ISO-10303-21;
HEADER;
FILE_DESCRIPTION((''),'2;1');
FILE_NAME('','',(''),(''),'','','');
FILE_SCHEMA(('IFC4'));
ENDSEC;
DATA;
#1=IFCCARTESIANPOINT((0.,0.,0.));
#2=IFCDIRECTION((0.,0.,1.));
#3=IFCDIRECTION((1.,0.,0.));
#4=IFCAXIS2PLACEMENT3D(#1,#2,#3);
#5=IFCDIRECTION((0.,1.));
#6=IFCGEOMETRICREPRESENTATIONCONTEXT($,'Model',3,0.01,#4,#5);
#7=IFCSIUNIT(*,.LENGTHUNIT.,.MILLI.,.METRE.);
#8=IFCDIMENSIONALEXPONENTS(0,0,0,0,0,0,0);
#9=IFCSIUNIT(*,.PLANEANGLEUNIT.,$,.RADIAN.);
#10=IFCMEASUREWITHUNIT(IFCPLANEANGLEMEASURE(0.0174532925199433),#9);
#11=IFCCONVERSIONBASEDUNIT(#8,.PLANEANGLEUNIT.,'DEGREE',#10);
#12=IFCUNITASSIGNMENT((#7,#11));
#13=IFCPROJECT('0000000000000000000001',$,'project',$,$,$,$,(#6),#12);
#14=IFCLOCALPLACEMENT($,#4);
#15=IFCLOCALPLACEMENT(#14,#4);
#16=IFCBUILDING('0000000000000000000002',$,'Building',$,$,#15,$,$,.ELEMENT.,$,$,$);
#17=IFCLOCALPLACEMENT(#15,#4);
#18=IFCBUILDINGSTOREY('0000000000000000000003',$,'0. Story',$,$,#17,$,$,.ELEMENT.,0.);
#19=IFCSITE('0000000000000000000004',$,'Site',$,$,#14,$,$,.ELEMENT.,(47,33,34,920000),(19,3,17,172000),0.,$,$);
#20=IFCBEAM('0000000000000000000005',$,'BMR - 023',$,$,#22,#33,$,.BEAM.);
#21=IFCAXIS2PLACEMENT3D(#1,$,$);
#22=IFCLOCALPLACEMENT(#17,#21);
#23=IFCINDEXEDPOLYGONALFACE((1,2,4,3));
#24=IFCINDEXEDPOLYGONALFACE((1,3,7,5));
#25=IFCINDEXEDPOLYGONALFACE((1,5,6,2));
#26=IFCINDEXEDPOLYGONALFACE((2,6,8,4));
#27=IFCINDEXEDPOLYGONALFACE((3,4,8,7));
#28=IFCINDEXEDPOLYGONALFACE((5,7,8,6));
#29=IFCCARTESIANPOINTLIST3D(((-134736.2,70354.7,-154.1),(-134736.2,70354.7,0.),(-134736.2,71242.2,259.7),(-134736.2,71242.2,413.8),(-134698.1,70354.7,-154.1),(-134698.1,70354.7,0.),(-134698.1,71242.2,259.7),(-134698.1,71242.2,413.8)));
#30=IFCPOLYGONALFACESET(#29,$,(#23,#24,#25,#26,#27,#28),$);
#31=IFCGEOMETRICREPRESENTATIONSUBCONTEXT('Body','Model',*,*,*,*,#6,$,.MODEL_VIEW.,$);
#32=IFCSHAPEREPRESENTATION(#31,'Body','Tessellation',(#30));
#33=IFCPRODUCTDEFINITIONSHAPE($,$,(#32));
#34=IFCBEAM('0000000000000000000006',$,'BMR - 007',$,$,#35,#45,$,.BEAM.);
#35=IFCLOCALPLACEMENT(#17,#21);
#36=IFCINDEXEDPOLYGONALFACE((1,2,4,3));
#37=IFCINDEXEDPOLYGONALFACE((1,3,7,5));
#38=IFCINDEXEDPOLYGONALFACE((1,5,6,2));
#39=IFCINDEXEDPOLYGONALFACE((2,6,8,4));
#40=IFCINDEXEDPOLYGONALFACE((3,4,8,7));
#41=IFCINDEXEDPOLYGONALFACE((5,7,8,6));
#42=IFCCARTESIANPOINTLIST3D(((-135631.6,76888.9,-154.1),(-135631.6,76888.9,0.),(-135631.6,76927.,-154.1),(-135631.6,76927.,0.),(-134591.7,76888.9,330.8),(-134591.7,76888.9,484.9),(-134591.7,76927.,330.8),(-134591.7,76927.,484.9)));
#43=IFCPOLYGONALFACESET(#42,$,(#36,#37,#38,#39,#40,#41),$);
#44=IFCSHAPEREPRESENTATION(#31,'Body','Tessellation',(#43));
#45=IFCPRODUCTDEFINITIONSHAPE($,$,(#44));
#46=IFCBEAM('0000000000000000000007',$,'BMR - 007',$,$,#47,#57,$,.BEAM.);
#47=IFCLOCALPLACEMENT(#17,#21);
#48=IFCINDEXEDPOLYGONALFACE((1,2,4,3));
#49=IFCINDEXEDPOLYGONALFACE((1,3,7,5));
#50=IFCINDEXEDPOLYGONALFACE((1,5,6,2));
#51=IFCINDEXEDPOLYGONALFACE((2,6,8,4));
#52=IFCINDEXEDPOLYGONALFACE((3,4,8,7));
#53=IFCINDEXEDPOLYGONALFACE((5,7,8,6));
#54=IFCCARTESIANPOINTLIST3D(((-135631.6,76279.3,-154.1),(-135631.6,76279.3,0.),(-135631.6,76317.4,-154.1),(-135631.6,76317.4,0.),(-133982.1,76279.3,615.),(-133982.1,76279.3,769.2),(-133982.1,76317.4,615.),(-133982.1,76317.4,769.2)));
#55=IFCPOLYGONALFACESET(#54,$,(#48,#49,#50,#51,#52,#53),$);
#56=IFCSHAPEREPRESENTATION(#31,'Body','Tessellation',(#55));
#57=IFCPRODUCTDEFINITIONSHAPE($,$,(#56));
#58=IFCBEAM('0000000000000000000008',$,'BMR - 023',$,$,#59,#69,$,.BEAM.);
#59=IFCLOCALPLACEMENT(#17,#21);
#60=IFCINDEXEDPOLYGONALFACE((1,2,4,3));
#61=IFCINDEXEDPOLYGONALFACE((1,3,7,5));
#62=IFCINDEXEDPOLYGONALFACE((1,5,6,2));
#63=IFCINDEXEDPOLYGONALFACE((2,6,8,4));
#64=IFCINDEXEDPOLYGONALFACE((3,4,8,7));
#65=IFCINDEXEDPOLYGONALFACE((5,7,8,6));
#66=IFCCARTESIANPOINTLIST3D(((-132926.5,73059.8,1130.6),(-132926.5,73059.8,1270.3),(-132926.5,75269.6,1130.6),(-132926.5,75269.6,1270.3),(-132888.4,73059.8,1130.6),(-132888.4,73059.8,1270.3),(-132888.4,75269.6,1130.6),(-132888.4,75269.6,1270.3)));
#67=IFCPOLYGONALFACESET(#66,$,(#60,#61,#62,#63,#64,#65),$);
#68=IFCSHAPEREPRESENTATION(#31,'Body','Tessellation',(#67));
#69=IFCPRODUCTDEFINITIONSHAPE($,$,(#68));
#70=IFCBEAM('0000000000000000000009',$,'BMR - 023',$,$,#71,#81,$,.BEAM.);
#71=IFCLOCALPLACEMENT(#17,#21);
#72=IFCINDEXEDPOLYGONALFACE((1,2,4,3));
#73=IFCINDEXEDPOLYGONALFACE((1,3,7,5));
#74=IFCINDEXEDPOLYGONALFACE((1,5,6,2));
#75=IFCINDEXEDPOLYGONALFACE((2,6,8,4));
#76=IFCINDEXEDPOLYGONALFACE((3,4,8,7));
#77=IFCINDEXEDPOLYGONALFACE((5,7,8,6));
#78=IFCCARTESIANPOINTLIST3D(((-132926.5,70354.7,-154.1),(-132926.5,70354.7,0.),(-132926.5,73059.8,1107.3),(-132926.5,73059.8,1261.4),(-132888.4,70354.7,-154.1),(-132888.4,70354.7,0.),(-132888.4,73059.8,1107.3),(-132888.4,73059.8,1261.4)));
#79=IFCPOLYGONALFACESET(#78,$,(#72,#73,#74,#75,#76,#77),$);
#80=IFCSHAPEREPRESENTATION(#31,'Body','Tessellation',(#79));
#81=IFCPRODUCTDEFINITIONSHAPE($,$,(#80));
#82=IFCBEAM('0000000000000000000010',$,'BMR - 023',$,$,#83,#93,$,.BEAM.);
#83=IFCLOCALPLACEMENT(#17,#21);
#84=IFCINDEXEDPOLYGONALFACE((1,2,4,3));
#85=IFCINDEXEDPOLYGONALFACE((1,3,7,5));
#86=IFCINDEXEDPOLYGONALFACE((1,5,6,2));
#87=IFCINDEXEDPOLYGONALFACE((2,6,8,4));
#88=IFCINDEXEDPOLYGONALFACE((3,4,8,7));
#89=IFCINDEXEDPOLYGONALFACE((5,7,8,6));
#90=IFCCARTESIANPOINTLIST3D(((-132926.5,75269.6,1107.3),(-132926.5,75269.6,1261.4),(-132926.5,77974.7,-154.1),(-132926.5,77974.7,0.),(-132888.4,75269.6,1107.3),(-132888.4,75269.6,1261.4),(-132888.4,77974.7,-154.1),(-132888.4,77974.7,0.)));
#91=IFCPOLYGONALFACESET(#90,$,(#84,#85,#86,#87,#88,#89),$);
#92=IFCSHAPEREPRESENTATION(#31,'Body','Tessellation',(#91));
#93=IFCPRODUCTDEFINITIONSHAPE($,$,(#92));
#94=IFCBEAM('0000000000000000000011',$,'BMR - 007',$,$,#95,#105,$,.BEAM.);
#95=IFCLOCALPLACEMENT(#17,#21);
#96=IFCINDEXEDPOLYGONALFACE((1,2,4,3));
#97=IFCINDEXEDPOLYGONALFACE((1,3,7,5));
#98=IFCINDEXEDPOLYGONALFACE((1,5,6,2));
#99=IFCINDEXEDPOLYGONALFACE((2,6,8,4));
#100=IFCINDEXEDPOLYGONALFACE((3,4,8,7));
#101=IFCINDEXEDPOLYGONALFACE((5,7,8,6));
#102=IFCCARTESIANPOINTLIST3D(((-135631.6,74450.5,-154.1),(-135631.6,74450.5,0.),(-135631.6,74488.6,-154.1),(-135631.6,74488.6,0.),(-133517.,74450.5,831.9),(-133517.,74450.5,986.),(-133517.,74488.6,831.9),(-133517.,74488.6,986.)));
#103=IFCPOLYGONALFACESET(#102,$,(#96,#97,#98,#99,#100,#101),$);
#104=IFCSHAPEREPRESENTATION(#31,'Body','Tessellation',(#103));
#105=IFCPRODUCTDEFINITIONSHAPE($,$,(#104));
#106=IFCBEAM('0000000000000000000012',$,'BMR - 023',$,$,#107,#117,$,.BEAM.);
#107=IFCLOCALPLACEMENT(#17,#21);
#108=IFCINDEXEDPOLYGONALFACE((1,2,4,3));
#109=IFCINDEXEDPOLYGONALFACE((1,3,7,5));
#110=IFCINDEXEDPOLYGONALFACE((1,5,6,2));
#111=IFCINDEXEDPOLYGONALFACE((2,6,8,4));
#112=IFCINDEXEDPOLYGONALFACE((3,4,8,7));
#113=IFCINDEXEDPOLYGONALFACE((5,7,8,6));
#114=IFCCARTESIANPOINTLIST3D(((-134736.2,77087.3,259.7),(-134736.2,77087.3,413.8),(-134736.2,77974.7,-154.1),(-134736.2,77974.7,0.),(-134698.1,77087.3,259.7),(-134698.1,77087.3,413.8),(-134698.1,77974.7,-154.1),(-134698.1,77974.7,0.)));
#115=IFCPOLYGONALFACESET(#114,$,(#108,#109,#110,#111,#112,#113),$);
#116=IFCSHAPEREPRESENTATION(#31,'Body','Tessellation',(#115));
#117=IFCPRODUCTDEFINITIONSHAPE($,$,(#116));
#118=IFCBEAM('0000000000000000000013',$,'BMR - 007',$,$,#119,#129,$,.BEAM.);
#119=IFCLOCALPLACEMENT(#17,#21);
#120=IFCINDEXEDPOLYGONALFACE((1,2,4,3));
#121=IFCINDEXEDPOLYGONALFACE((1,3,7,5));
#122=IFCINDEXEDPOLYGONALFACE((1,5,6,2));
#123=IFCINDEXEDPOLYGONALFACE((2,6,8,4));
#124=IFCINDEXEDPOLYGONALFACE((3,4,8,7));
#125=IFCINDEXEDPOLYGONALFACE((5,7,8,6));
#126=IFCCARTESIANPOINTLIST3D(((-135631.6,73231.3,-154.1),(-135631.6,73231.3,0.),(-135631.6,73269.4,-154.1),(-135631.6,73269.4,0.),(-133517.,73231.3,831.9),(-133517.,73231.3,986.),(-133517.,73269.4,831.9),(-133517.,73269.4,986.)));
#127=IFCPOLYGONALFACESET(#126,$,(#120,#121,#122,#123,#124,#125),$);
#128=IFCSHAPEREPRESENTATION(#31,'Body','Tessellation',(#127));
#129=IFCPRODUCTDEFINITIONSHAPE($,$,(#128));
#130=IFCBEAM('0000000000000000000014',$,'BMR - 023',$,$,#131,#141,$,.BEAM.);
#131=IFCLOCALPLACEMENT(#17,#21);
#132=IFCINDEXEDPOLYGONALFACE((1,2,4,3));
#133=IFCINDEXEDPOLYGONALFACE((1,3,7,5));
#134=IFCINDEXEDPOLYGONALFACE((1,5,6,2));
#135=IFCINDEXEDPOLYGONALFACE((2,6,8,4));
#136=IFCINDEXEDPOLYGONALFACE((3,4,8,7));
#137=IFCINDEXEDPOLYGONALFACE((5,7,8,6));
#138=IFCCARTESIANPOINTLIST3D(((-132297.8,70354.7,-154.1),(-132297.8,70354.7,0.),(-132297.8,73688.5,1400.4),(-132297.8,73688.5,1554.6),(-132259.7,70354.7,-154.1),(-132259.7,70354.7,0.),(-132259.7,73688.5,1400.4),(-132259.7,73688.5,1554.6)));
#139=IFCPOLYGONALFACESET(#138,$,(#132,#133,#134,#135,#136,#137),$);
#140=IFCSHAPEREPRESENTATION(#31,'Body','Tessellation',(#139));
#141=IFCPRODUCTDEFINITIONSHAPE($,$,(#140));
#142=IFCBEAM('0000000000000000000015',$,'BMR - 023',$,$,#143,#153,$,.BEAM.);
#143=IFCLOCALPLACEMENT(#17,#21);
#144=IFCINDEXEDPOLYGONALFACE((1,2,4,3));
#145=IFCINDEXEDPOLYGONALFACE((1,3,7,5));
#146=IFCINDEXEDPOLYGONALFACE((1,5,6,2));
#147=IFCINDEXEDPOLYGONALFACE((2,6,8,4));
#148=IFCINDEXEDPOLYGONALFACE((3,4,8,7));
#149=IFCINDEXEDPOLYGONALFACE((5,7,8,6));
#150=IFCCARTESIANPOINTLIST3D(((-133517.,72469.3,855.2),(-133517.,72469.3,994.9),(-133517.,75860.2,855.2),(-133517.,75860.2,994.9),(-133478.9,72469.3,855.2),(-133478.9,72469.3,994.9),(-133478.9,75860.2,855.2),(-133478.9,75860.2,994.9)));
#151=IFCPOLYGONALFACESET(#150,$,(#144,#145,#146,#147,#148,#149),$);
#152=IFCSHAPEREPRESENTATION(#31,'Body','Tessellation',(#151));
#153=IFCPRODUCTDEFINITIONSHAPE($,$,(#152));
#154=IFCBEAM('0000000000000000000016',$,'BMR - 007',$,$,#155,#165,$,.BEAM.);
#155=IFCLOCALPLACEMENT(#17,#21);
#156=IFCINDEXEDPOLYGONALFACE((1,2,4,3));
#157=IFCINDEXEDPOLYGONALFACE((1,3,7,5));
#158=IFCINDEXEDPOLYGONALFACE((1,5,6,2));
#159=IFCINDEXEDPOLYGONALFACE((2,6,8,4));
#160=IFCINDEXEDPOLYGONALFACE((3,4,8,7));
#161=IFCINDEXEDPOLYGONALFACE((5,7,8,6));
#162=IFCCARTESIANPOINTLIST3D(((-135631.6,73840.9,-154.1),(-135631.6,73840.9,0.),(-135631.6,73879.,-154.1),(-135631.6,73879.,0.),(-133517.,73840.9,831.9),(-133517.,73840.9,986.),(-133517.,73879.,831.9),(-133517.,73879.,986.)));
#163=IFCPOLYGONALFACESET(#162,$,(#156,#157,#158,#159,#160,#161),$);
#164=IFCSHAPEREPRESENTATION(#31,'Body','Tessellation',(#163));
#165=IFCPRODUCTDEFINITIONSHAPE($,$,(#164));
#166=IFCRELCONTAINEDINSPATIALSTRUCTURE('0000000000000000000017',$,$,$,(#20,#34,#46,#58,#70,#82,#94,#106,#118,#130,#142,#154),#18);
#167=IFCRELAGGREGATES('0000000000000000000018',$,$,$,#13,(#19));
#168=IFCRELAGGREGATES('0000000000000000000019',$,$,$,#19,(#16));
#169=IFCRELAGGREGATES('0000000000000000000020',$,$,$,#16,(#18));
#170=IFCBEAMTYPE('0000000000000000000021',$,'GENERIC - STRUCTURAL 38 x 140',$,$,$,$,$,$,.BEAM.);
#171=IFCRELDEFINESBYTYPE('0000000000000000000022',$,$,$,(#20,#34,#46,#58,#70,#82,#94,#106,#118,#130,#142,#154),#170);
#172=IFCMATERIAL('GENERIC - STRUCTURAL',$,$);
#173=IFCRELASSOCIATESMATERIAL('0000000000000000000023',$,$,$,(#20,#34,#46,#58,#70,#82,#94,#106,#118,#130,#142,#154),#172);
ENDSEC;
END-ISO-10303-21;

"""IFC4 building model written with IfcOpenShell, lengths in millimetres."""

from ifc_helpers import new_model, entity, si_unit, converted_unit, direction, frame, frame_2d, origin_with_axes, place, context, subcontext, project, spatial, rectangle, extrude, clip, halfspace, material, type_object, element, save


model = new_model("IFC4")

# Units and contexts
model_context = context("Model", 3, precision=0.01, world=origin_with_axes(), true_north=direction((0.0, 1.0)))
body_context = subcontext(model_context, "Body", "Model", "MODEL_VIEW")
ifc_project = project(units=[si_unit("LENGTHUNIT", "METRE", prefix="MILLI"), converted_unit("PLANEANGLEUNIT", "DEGREE", entity("IfcPlaneAngleMeasure", 0.0174532925199433), si_unit("PLANEANGLEUNIT", "RADIAN"), dimensions=[0, 0, 0, 0, 0, 0, 0])], contexts=[model_context])

# Site, building, storey
site_placement = place(None, origin_with_axes())
site = spatial("IfcSite", under=ifc_project, at=site_placement, Name="Site", CompositionType="ELEMENT", RefLatitude=(47, 33, 34, 920000), RefLongitude=(19, 3, 17, 172000), RefElevation=0.0)
building_placement = place(site_placement, origin_with_axes())
building = spatial("IfcBuilding", under=site, at=building_placement, Name="Building", CompositionType="ELEMENT")
storey_placement = place(building_placement, origin_with_axes())
storey = spatial("IfcBuildingStorey", under=building, at=storey_placement, Name="0. Story", CompositionType="ELEMENT", Elevation=0.0)

# Beams
ifc_material = material(Name="GENERIC - STRUCTURAL")
beam_type = type_object("IfcBeamType", Name="GENERIC - STRUCTURAL 38 x 140", PredefinedType="BEAM")
beam_1_placement = place(storey_placement, frame((-134717.2, 70354.7, 0.0), z_axis=(0.0, 0.0, 1.0), x_axis=(1.0, 0.0, 0.0)))
element("IfcBeam", 1, at=beam_1_placement, inside=storey, type_object=beam_type, material=ifc_material, Name="BMR - 023", PredefinedType="BEAM", context=body_context, shape_type="Clipping", body=[
    clip(clip(extrude(rectangle(XDim=139.7, YDim=38.1, at=frame_2d((-69.8, 0.0), x_axis=(1.0, 0.0))), frame((0.0, -83.5, -38.9), z_axis=(0.0, 0.906308, 0.422618), x_axis=(0.0, -0.422618, 0.906308)), (0.0, 0.0, 1.0), 1163.5), halfspace(frame((0.0, 0.0, 0.0), z_axis=(0.0, 1.0, 0.0), x_axis=(0.0, 0.0, 1.0)), True)), halfspace(frame((0.0, 887.5, 0.0), z_axis=(0.0, -1.0, 0.0), x_axis=(0.0, 0.0, -1.0)), True)),
])
beam_2_placement = place(storey_placement, frame((-135631.6, 76907.9, 0.0), z_axis=(0.0, 0.0, 1.0), x_axis=(0.0, -1.0, 0.0)))
element("IfcBeam", 2, at=beam_2_placement, inside=storey, type_object=beam_type, material=ifc_material, Name="BMR - 007", PredefinedType="BEAM", context=body_context, shape_type="Clipping", body=[
    clip(clip(extrude(rectangle(XDim=139.7, YDim=38.1, at=frame_2d((-69.8, 0.0), x_axis=(1.0, 0.0))), frame((0.0, -83.5, -38.9), z_axis=(0.0, 0.906308, 0.422618), x_axis=(0.0, -0.422618, 0.906308)), (0.0, 0.0, 1.0), 1331.6), halfspace(frame((0.0, 0.0, 0.0), z_axis=(0.0, 1.0, 0.0), x_axis=(0.0, 0.0, 1.0)), True)), halfspace(frame((0.0, 1039.9, 0.0), z_axis=(0.0, -1.0, 0.0), x_axis=(0.0, 0.0, -1.0)), True)),
])
beam_3_placement = place(storey_placement, frame((-135631.6, 76298.3, 0.0), z_axis=(0.0, 0.0, 1.0), x_axis=(0.0, -1.0, 0.0)))
element("IfcBeam", 3, at=beam_3_placement, inside=storey, type_object=beam_type, material=ifc_material, Name="BMR - 007", PredefinedType="BEAM", context=body_context, shape_type="Clipping", body=[
    clip(clip(extrude(rectangle(XDim=139.7, YDim=38.1, at=frame_2d((-69.8, 0.0), x_axis=(1.0, 0.0))), frame((0.0, -83.5, -38.9), z_axis=(0.0, 0.906308, 0.422618), x_axis=(0.0, -0.422618, 0.906308)), (0.0, 0.0, 1.0), 2004.2), halfspace(frame((0.0, 0.0, 0.0), z_axis=(0.0, 1.0, 0.0), x_axis=(0.0, 0.0, 1.0)), True)), halfspace(frame((0.0, 1649.5, 0.0), z_axis=(0.0, -1.0, 0.0), x_axis=(0.0, 0.0, -1.0)), True)),
])
beam_4_placement = place(storey_placement, frame((-132907.4, 75269.6, 1270.3), z_axis=(0.0, 0.0, 1.0), x_axis=(-1.0, 0.0, 0.0)))
element("IfcBeam", 4, at=beam_4_placement, inside=storey, type_object=beam_type, material=ifc_material, Name="BMR - 023", PredefinedType="BEAM", context=body_context, shape_type="SweptSolid", body=[
    extrude(rectangle(XDim=139.7, YDim=38.1, at=frame_2d((-69.8, 0.0), x_axis=(1.0, 0.0))), frame((0.0, 0.0, 0.0), z_axis=(0.0, 1.0, 0.0), x_axis=(0.0, 0.0, 1.0)), (0.0, 0.0, 1.0), 2209.8),
])
beam_5_placement = place(storey_placement, frame((-132907.4, 70354.7, 0.0), z_axis=(0.0, 0.0, 1.0), x_axis=(1.0, 0.0, 0.0)))
element("IfcBeam", 5, at=beam_5_placement, inside=storey, type_object=beam_type, material=ifc_material, Name="BMR - 023", PredefinedType="BEAM", context=body_context, shape_type="Clipping", body=[
    clip(clip(extrude(rectangle(XDim=139.7, YDim=38.1, at=frame_2d((-69.8, 0.0), x_axis=(1.0, 0.0))), frame((0.0, -83.5, -38.9), z_axis=(0.0, 0.906308, 0.422618), x_axis=(0.0, -0.422618, 0.906308)), (0.0, 0.0, 1.0), 3169.0), halfspace(frame((0.0, 0.0, 0.0), z_axis=(0.0, 1.0, 0.0), x_axis=(0.0, 0.0, 1.0)), True)), halfspace(frame((0.0, 2705.1, 0.0), z_axis=(0.0, -1.0, 0.0), x_axis=(0.0, 0.0, -1.0)), True)),
])
beam_6_placement = place(storey_placement, frame((-132907.4, 77974.7, 0.0), z_axis=(0.0, 0.0, 1.0), x_axis=(-1.0, 0.0, 0.0)))
element("IfcBeam", 6, at=beam_6_placement, inside=storey, type_object=beam_type, material=ifc_material, Name="BMR - 023", PredefinedType="BEAM", context=body_context, shape_type="Clipping", body=[
    clip(clip(extrude(rectangle(XDim=139.7, YDim=38.1, at=frame_2d((-69.8, 0.0), x_axis=(1.0, 0.0))), frame((0.0, -83.5, -38.9), z_axis=(0.0, 0.906308, 0.422618), x_axis=(0.0, -0.422618, 0.906308)), (0.0, 0.0, 1.0), 3169.0), halfspace(frame((0.0, 0.0, 0.0), z_axis=(0.0, 1.0, 0.0), x_axis=(0.0, 0.0, 1.0)), True)), halfspace(frame((0.0, 2705.1, 0.0), z_axis=(0.0, -1.0, 0.0), x_axis=(0.0, 0.0, -1.0)), True)),
])
beam_7_placement = place(storey_placement, frame((-135631.6, 74469.5, 0.0), z_axis=(0.0, 0.0, 1.0), x_axis=(0.0, -1.0, 0.0)))
element("IfcBeam", 7, at=beam_7_placement, inside=storey, type_object=beam_type, material=ifc_material, Name="BMR - 007", PredefinedType="BEAM", context=body_context, shape_type="Clipping", body=[
    clip(clip(extrude(rectangle(XDim=139.7, YDim=38.1, at=frame_2d((-69.8, 0.0), x_axis=(1.0, 0.0))), frame((0.0, -83.5, -38.9), z_axis=(0.0, 0.906308, 0.422618), x_axis=(0.0, -0.422618, 0.906308)), (0.0, 0.0, 1.0), 2517.4), halfspace(frame((0.0, 0.0, 0.0), z_axis=(0.0, 1.0, 0.0), x_axis=(0.0, 0.0, 1.0)), True)), halfspace(frame((0.0, 2114.5, 0.0), z_axis=(0.0, -1.0, 0.0), x_axis=(0.0, 0.0, -1.0)), True)),
])
beam_8_placement = place(storey_placement, frame((-134717.2, 77974.7, 0.0), z_axis=(0.0, 0.0, 1.0), x_axis=(-1.0, 0.0, 0.0)))
element("IfcBeam", 8, at=beam_8_placement, inside=storey, type_object=beam_type, material=ifc_material, Name="BMR - 023", PredefinedType="BEAM", context=body_context, shape_type="Clipping", body=[
    clip(clip(extrude(rectangle(XDim=139.7, YDim=38.1, at=frame_2d((-69.8, 0.0), x_axis=(1.0, 0.0))), frame((0.0, -83.5, -38.9), z_axis=(0.0, 0.906308, 0.422618), x_axis=(0.0, -0.422618, 0.906308)), (0.0, 0.0, 1.0), 1163.5), halfspace(frame((0.0, 0.0, 0.0), z_axis=(0.0, 1.0, 0.0), x_axis=(0.0, 0.0, 1.0)), True)), halfspace(frame((0.0, 887.5, 0.0), z_axis=(0.0, -1.0, 0.0), x_axis=(0.0, 0.0, -1.0)), True)),
])
beam_9_placement = place(storey_placement, frame((-135631.6, 73250.3, 0.0), z_axis=(0.0, 0.0, 1.0), x_axis=(0.0, -1.0, 0.0)))
element("IfcBeam", 9, at=beam_9_placement, inside=storey, type_object=beam_type, material=ifc_material, Name="BMR - 007", PredefinedType="BEAM", context=body_context, shape_type="Clipping", body=[
    clip(clip(extrude(rectangle(XDim=139.7, YDim=38.1, at=frame_2d((-69.8, 0.0), x_axis=(1.0, 0.0))), frame((0.0, -83.5, -38.9), z_axis=(0.0, 0.906308, 0.422618), x_axis=(0.0, -0.422618, 0.906308)), (0.0, 0.0, 1.0), 2517.4), halfspace(frame((0.0, 0.0, 0.0), z_axis=(0.0, 1.0, 0.0), x_axis=(0.0, 0.0, 1.0)), True)), halfspace(frame((0.0, 2114.5, 0.0), z_axis=(0.0, -1.0, 0.0), x_axis=(0.0, 0.0, -1.0)), True)),
])
beam_10_placement = place(storey_placement, frame((-132278.8, 70354.7, 0.0), z_axis=(0.0, 0.0, 1.0), x_axis=(1.0, 0.0, 0.0)))
element("IfcBeam", 10, at=beam_10_placement, inside=storey, type_object=beam_type, material=ifc_material, Name="BMR - 023", PredefinedType="BEAM", context=body_context, shape_type="Clipping", body=[
    clip(clip(extrude(rectangle(XDim=139.7, YDim=38.1, at=frame_2d((-69.8, 0.0), x_axis=(1.0, 0.0))), frame((0.0, -83.5, -38.9), z_axis=(0.0, 0.906308, 0.422618), x_axis=(0.0, -0.422618, 0.906308)), (0.0, 0.0, 1.0), 3862.6), halfspace(frame((0.0, 0.0, 0.0), z_axis=(0.0, 1.0, 0.0), x_axis=(0.0, 0.0, 1.0)), True)), halfspace(frame((0.0, 3333.7, 0.0), z_axis=(0.0, -1.0, 0.0), x_axis=(0.0, 0.0, -1.0)), True)),
])
beam_11_placement = place(storey_placement, frame((-133498.0, 75860.2, 994.9), z_axis=(0.0, 0.0, 1.0), x_axis=(-1.0, 0.0, 0.0)))
element("IfcBeam", 11, at=beam_11_placement, inside=storey, type_object=beam_type, material=ifc_material, Name="BMR - 023", PredefinedType="BEAM", context=body_context, shape_type="SweptSolid", body=[
    extrude(rectangle(XDim=139.7, YDim=38.1, at=frame_2d((-69.8, 0.0), x_axis=(1.0, 0.0))), frame((0.0, 0.0, 0.0), z_axis=(0.0, 1.0, 0.0), x_axis=(0.0, 0.0, 1.0)), (0.0, 0.0, 1.0), 3390.9),
])
beam_12_placement = place(storey_placement, frame((-135631.6, 73859.9, 0.0), z_axis=(0.0, 0.0, 1.0), x_axis=(0.0, -1.0, 0.0)))
element("IfcBeam", 12, at=beam_12_placement, inside=storey, type_object=beam_type, material=ifc_material, Name="BMR - 007", PredefinedType="BEAM", context=body_context, shape_type="Clipping", body=[
    clip(clip(extrude(rectangle(XDim=139.7, YDim=38.1, at=frame_2d((-69.8, 0.0), x_axis=(1.0, 0.0))), frame((0.0, -83.5, -38.9), z_axis=(0.0, 0.906308, 0.422618), x_axis=(0.0, -0.422618, 0.906308)), (0.0, 0.0, 1.0), 2517.4), halfspace(frame((0.0, 0.0, 0.0), z_axis=(0.0, 1.0, 0.0), x_axis=(0.0, 0.0, 1.0)), True)), halfspace(frame((0.0, 2114.5, 0.0), z_axis=(0.0, -1.0, 0.0), x_axis=(0.0, 0.0, -1.0)), True)),
])

save(model, "model.ifc")
